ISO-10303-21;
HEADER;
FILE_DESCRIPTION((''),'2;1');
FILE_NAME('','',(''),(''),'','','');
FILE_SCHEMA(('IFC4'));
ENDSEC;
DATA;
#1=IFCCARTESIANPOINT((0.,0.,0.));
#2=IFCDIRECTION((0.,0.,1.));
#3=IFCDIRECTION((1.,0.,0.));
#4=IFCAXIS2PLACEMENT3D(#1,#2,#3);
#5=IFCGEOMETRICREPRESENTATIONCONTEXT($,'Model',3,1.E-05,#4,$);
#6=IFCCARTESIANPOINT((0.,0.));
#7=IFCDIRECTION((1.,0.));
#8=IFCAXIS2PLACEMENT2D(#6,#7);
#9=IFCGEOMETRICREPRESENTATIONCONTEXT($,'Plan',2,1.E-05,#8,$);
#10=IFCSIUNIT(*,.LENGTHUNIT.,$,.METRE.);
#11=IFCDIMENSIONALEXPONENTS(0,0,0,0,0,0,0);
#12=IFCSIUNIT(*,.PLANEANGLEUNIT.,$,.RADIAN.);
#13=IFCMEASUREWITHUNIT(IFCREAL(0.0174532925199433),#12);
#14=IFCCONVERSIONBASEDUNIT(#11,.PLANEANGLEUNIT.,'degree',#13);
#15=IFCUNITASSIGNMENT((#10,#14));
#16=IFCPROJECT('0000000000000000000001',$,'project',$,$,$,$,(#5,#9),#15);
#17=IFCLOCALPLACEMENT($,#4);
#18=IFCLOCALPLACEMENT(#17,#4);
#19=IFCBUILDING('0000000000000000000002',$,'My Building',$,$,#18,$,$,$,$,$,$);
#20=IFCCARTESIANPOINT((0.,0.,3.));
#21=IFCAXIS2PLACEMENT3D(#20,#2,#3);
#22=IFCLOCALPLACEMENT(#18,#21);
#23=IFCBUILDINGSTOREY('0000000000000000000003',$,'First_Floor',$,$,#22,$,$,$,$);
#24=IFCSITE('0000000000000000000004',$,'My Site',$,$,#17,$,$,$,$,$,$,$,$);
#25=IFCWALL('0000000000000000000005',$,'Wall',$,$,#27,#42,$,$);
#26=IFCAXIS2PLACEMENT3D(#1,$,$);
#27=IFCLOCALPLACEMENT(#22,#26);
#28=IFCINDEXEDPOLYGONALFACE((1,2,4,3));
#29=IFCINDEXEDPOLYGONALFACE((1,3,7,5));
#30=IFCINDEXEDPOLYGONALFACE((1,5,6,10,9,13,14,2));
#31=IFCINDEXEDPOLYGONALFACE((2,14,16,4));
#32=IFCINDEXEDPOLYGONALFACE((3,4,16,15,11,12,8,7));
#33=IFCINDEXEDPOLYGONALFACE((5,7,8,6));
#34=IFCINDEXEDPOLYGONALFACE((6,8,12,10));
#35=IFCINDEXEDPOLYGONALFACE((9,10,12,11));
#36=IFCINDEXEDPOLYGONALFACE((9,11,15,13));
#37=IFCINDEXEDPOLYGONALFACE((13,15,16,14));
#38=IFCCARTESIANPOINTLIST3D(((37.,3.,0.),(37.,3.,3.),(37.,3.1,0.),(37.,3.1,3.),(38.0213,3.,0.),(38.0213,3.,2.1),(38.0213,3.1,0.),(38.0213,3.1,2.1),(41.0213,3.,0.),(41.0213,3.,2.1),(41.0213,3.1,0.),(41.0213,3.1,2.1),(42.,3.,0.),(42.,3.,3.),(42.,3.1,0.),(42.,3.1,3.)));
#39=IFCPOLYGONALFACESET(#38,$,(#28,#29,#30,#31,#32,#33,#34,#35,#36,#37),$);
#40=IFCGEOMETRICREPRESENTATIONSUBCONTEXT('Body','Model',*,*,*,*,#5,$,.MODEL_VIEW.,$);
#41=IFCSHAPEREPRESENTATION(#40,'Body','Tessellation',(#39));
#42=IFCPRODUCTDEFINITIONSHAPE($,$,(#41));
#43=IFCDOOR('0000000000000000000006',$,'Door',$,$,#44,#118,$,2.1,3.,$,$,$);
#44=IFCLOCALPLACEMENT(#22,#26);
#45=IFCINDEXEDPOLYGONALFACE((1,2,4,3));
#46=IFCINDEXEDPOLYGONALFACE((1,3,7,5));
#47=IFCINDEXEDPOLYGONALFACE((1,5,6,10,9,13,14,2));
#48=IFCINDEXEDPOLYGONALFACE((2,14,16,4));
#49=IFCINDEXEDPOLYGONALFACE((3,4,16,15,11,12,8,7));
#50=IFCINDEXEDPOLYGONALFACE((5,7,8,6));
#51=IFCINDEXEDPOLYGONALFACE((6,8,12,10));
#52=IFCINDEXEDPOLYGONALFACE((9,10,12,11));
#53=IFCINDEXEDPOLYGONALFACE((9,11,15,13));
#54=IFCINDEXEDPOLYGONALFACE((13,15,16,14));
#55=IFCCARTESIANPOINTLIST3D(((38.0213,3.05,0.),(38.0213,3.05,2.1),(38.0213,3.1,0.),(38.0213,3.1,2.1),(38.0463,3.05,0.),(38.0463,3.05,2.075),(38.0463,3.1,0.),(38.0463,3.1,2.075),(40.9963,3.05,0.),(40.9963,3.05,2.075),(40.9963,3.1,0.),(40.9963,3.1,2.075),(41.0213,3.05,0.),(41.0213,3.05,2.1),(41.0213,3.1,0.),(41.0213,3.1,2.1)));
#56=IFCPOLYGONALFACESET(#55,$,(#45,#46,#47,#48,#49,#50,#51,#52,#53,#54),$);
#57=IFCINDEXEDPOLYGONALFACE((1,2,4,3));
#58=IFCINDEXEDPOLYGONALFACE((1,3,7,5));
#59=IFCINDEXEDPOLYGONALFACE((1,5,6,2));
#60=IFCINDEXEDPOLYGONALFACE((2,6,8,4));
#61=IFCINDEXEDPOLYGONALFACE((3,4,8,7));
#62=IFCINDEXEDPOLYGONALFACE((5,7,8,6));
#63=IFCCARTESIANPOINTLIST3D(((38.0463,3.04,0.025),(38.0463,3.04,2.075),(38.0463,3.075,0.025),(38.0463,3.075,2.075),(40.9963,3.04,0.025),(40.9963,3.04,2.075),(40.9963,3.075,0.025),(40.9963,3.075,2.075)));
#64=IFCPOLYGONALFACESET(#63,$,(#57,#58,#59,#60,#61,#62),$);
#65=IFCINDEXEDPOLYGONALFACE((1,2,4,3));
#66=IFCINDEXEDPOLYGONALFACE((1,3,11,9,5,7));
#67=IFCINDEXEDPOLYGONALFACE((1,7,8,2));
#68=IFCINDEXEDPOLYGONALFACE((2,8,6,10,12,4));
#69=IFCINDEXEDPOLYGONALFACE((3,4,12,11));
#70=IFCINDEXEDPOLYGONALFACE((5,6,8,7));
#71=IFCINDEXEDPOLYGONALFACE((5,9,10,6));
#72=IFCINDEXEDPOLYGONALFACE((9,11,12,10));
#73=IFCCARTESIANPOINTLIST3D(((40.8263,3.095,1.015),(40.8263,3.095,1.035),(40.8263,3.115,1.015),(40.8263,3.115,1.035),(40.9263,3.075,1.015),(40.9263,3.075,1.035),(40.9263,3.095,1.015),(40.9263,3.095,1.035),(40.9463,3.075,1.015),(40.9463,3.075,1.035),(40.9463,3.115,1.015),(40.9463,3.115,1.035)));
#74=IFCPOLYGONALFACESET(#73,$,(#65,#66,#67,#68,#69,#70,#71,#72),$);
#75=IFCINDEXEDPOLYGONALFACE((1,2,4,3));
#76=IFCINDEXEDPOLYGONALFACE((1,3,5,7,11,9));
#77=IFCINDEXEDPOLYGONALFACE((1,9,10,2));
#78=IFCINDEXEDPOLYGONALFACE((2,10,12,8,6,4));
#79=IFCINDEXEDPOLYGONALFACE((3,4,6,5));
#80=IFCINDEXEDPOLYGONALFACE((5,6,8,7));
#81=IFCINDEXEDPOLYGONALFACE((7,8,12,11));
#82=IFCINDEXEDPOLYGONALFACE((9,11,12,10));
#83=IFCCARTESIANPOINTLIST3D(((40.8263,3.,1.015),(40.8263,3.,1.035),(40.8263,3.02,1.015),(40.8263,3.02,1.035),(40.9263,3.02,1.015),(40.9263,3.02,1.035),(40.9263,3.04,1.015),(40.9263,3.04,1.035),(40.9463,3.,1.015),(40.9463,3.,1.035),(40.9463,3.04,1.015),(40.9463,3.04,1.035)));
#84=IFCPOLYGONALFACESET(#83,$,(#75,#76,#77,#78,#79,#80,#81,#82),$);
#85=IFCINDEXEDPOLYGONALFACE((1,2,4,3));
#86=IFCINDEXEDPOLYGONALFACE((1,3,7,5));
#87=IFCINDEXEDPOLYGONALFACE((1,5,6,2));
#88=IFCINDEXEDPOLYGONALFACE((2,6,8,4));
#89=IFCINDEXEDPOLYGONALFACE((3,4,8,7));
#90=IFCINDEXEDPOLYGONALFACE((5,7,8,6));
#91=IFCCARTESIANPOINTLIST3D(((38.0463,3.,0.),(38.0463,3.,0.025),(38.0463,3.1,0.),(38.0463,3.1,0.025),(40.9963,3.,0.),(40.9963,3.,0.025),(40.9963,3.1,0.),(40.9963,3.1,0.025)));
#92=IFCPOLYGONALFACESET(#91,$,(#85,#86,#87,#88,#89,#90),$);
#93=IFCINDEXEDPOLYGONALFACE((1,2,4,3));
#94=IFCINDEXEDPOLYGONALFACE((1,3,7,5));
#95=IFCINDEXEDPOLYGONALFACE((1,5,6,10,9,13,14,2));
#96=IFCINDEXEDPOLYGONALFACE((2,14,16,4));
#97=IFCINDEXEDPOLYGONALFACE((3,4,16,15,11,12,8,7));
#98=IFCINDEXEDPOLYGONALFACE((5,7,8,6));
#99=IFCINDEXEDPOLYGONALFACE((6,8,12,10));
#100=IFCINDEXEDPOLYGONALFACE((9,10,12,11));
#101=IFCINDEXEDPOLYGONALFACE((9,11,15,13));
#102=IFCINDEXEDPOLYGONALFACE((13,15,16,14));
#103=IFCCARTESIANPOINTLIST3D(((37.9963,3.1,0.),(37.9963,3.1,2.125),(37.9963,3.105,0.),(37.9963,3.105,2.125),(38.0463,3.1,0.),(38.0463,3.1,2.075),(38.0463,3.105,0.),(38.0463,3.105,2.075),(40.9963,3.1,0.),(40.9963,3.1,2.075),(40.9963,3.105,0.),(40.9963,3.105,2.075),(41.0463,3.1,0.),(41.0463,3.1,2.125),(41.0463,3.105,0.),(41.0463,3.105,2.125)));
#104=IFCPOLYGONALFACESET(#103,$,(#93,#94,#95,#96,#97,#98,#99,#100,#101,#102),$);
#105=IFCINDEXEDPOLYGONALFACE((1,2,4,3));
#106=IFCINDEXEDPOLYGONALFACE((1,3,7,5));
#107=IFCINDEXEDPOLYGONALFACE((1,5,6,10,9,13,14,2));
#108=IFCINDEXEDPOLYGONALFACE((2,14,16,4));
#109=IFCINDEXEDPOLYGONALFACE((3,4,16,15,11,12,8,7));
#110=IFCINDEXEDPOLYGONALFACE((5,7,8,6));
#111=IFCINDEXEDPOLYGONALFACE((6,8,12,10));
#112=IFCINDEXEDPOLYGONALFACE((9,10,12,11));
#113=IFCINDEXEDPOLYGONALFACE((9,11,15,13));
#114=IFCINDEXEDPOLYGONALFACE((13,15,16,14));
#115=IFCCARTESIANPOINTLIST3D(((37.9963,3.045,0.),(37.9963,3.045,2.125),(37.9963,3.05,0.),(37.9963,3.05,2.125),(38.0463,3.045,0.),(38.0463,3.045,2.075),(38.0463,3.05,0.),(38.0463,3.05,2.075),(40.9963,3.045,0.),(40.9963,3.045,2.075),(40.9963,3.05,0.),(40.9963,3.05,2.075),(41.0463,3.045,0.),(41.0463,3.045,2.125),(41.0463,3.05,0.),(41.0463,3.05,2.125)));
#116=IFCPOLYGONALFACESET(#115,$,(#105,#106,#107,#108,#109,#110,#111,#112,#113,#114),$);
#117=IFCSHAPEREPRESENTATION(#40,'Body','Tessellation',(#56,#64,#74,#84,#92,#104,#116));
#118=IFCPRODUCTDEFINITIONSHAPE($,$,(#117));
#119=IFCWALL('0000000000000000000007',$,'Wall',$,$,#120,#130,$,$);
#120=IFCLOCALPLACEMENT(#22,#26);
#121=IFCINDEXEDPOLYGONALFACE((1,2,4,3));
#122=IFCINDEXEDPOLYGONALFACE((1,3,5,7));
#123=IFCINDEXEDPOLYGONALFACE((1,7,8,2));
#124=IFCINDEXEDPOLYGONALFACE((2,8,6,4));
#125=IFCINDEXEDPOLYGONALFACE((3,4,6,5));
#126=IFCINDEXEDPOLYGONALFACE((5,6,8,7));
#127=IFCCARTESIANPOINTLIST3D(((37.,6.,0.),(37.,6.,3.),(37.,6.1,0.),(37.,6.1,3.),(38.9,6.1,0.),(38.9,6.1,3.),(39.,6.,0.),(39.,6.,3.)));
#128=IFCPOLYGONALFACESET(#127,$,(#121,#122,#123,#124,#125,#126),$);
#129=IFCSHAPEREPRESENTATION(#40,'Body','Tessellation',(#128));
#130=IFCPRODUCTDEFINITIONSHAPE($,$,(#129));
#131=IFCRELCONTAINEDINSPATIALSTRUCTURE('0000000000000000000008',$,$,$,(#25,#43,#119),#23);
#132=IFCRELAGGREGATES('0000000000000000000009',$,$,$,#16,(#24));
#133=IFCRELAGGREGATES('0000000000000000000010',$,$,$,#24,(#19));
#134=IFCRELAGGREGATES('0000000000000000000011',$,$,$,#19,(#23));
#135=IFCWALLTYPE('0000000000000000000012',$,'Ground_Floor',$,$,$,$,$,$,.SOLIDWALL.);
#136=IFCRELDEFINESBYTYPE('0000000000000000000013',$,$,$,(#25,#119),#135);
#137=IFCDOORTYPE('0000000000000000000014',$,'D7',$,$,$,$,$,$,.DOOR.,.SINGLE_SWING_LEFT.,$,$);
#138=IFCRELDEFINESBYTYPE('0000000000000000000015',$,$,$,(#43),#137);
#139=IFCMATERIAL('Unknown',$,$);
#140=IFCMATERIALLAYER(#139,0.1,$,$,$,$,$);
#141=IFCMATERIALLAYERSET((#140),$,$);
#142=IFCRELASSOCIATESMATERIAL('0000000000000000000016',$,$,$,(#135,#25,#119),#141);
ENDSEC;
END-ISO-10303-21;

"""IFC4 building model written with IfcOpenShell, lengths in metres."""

from ifc_helpers import new_model, entity, si_unit, converted_unit, frame, origin_with_axes, origin_2d_with_axis, place, context, subcontext, project, spatial, line, indexed_curve, outline, extrude, shape, source, transform, mapped, material, layer, layer_set, layer_usage, type_object, type_shapes, element, fill, save


model = new_model("IFC4")

# Units and contexts
model_context = context("Model", 3, precision=1e-05, world=origin_with_axes())
plan_context = context("Plan", 2, precision=1e-05, world=origin_2d_with_axis())
body_context_1 = subcontext(model_context, "Body", "Model", "MODEL_VIEW")
body_context_2 = subcontext(plan_context, "Body", "Plan", "PLAN_VIEW")
ifc_project = project(units=[si_unit("LENGTHUNIT", "METRE"), converted_unit("PLANEANGLEUNIT", "degree", entity("IfcReal", 0.0174532925199433), si_unit("PLANEANGLEUNIT", "RADIAN"), dimensions=[0, 0, 0, 0, 0, 0, 0])], contexts=[model_context, plan_context])

# Site, building, storey
site_placement = place(None, origin_with_axes())
site = spatial("IfcSite", under=ifc_project, at=site_placement, Name="My Site")
building_placement = place(site_placement, origin_with_axes())
building = spatial("IfcBuilding", under=site, at=building_placement, Name="My Building")
storey_placement = place(building_placement, frame((0.0, 0.0, 3.0), z_axis=(0.0, 0.0, 1.0), x_axis=(1.0, 0.0, 0.0)))
storey = spatial("IfcBuildingStorey", under=building, at=storey_placement, Name="First_Floor")

# Shared definitions
ifc_material = material(Name="Unknown")

# Wall, opening, door
ifc_layer = layer(ifc_material, 0.1)
ifc_layer_set = layer_set([ifc_layer])
ifc_layer_usage_1 = layer_usage(ifc_layer_set, "AXIS2", "POSITIVE", 0.0)
wall_type = type_object("IfcWallType", Name="Ground_Floor", PredefinedType="SOLIDWALL", material=ifc_layer_set)
wall_1_placement = place(storey_placement, frame((37.0, 3.0, 0.0), z_axis=(0.0, 0.0, 1.0), x_axis=(1.0, 0.0, 0.0)))
wall_1 = element("IfcWall", 1, at=wall_1_placement, inside=storey, type_object=wall_type, material=ifc_layer_usage_1, Name="Wall", context=body_context_1, shape_type="SweptSolid", body=[
    extrude(outline(indexed_curve([(0.0, 0.0), (0.0, 0.1), (5.0, 0.1), (5.0, 0.0)], segments=[line(1, 2, 3, 4, 1)])), origin_with_axes(), (0.0, 0.0, 1.0), 3.0),
])
shared_shape_1 = source(origin_with_axes(), body_context_1, "Body", "SweptSolid", [
    extrude(outline(indexed_curve([(0.0, 0.0), (3.0, 0.0), (3.0, 2.1), (0.0, 2.1)], segments=[line(1, 2, 3, 4, 1)])), frame((0.0, -0.6, 0.0), z_axis=(0.0, -1.0, 0.0), x_axis=(1.0, 0.0, 0.0)), (0.0, 0.0, -1.0), 1.2),
])
opening_1_placement = place(wall_1_placement, frame((4.0213, 0.1, 0.0), z_axis=(0.0, 0.0, 1.0), x_axis=(-1.0, 0.0, 0.0)))
opening_1 = element("IfcOpeningElement", 2, at=opening_1_placement, cuts=wall_1, PredefinedType="OPENING", context=body_context_1, shape_type="MappedRepresentation", body=[
    mapped(shared_shape_1, transform((0.0, 0.0, 0.0), x_axis=(1.0, 0.0, 0.0), y_axis=(0.0, 1.0, 0.0), z_axis=(0.0, 0.0, 1.0), scale=1.0)),
])
door_type_1 = type_object("IfcDoorType", Name="D7", OperationType="SINGLE_SWING_LEFT", PredefinedType="DOOR")
shared_shape_2 = source(origin_with_axes(), body_context_1, "Body", "SweptSolid", [
    extrude(outline(indexed_curve([(0.0, 0.0), (0.0, 2.1), (3.0, 2.1), (3.0, 0.0), (2.975, 0.0), (2.975, 2.075), (0.025, 2.075), (0.025, 0.0)], segments=[line(1, 2, 3, 4, 5, 6, 7, 8, 1)])), frame((0.0, 0.0, 0.0), z_axis=(0.0, -1.0, 0.0), x_axis=(1.0, 0.0, 0.0)), (0.0, 0.0, -1.0), 0.05),
    extrude(outline(indexed_curve([(0.0, 0.0), (2.95, 0.0), (2.95, 0.035), (0.0, 0.035)], segments=[line(1, 2, 3, 4, 1)])), frame((0.025, 0.025, 0.025), z_axis=(0.0, 0.0, 1.0), x_axis=(1.0, 0.0, 0.0)), (0.0, 0.0, 1.0), 2.05),
    extrude(outline(indexed_curve([(0.0, 0.0), (0.0, -0.04), (0.12, -0.04), (0.12, -0.02), (0.02, -0.02), (0.02, 0.0)], segments=[line(1, 2, 3, 4, 5, 6, 1)])), frame((0.075, 0.025, 1.015), z_axis=(0.0, 0.0, 1.0), x_axis=(1.0, 0.0, 0.0)), (0.0, 0.0, 1.0), 0.02),
    extrude(outline(indexed_curve([(0.0, 0.0), (0.0, 0.04), (0.12, 0.04), (0.12, 0.02), (0.02, 0.02), (0.02, 0.0)], segments=[line(1, 2, 3, 4, 5, 6, 1)])), frame((0.075, 0.06, 1.015), z_axis=(0.0, 0.0, 1.0), x_axis=(1.0, 0.0, 0.0)), (0.0, 0.0, 1.0), 0.02),
    extrude(outline(indexed_curve([(0.0, 0.0), (2.95, 0.0), (2.95, 0.1), (0.0, 0.1)], segments=[line(1, 2, 3, 4, 1)])), frame((0.025, 0.0, 0.0), z_axis=(0.0, 0.0, 1.0), x_axis=(1.0, 0.0, 0.0)), (0.0, 0.0, 1.0), 0.025),
    extrude(outline(indexed_curve([(0.0, 0.0), (0.0, 2.125), (3.05, 2.125), (3.05, 0.0), (3.0, 0.0), (3.0, 2.075), (0.05, 2.075), (0.05, 0.0)], segments=[line(1, 2, 3, 4, 5, 6, 7, 8, 1)])), frame((-0.025, -0.005, 0.0), z_axis=(0.0, -1.0, 0.0), x_axis=(1.0, 0.0, 0.0)), (0.0, 0.0, -1.0), 0.005),
    extrude(outline(indexed_curve([(0.0, 0.0), (0.0, 2.125), (3.05, 2.125), (3.05, 0.0), (3.0, 0.0), (3.0, 2.075), (0.05, 2.075), (0.05, 0.0)], segments=[line(1, 2, 3, 4, 5, 6, 7, 8, 1)])), frame((-0.025, 0.05, 0.0), z_axis=(0.0, -1.0, 0.0), x_axis=(1.0, 0.0, 0.0)), (0.0, 0.0, -1.0), 0.005),
])
shared_shape_3 = source(origin_with_axes(), body_context_2, "Body", "Curve2D", [
    entity("IfcIndexedPolyCurve", entity("IfcCartesianPointList2D", [[0.0, 0.0], [0.025, 0.0], [0.025, 0.05], [0.0, 0.05]]), [entity("IfcLineIndex", [1, 2, 3, 4, 1])]),
    entity("IfcIndexedPolyCurve", entity("IfcCartesianPointList2D", [[3.0, 0.0], [2.975, 0.0], [2.975, 0.05], [3.0, 0.05]]), [entity("IfcLineIndex", [1, 2, 3, 4, 1])]),
    entity("IfcIndexedPolyCurve", entity("IfcCartesianPointList2D", [[2.975, 0.05], [2.975, -2.9], [2.94, -2.9]])),
    entity("IfcTrimmedCurve", entity("IfcEllipse", entity("IfcAxis2Placement2D", entity("IfcCartesianPoint", [2.94, 0.05]), entity("IfcDirection", [1.0, 0.0])), 2.915, 2.95), [entity("IfcCartesianPoint", [2.94, 3.0])], [entity("IfcCartesianPoint", [2.94, -2.9])], True, "CARTESIAN"),
    entity("IfcIndexedPolyCurve", entity("IfcCartesianPointList2D", [[2.975, 0.05], [2.94, 0.05], [2.94, 3.0], [2.975, 3.0]]), [entity("IfcLineIndex", [1, 2, 3, 4, 1])]),
])
type_shapes(door_type_1, [shared_shape_2, shared_shape_3])
door_1_placement = place(opening_1_placement, frame((0.0, 0.0, 0.0), z_axis=(0.0, 0.0, 1.0), x_axis=(1.0, 0.0, 0.0)))
door_1 = element("IfcDoor", 3, at=door_1_placement, inside=storey, type_object=door_type_1, Name="Door", OverallHeight=2.1, OverallWidth=3.0, shapes=[
    shape(body_context_1, "Body", "MappedRepresentation", [mapped(shared_shape_2, transform((0.0, 0.0, 0.0), x_axis=(1.0, 0.0, 0.0), y_axis=(0.0, 1.0, 0.0), z_axis=(0.0, 0.0, 1.0), scale=1.0))]),
    shape(body_context_2, "Body", "MappedRepresentation", [mapped(shared_shape_3, transform((0.0, 0.0, 0.0), x_axis=(1.0, 0.0, 0.0), y_axis=(0.0, 1.0, 0.0), z_axis=(0.0, 0.0, 1.0), scale=1.0))]),
])
fill(opening_1, door_1)

# Wall
ifc_layer_usage_2 = layer_usage(ifc_layer_set, "AXIS2", "POSITIVE", 0.0)
wall_2_placement = place(storey_placement, frame((37.0, 6.0, 0.0), z_axis=(0.0, 0.0, 1.0), x_axis=(1.0, 0.0, 0.0)))
element("IfcWall", 4, at=wall_2_placement, inside=storey, type_object=wall_type, material=ifc_layer_usage_2, Name="Wall", context=body_context_1, shape_type="SweptSolid", body=[
    extrude(outline(indexed_curve([(0.0, 0.0), (0.0, 0.1), (1.9, 0.1), (2.0, 0.0)], segments=[line(1, 2, 3, 4, 1)])), origin_with_axes(), (0.0, 0.0, 1.0), 3.0),
])

save(model, "model.ifc")
